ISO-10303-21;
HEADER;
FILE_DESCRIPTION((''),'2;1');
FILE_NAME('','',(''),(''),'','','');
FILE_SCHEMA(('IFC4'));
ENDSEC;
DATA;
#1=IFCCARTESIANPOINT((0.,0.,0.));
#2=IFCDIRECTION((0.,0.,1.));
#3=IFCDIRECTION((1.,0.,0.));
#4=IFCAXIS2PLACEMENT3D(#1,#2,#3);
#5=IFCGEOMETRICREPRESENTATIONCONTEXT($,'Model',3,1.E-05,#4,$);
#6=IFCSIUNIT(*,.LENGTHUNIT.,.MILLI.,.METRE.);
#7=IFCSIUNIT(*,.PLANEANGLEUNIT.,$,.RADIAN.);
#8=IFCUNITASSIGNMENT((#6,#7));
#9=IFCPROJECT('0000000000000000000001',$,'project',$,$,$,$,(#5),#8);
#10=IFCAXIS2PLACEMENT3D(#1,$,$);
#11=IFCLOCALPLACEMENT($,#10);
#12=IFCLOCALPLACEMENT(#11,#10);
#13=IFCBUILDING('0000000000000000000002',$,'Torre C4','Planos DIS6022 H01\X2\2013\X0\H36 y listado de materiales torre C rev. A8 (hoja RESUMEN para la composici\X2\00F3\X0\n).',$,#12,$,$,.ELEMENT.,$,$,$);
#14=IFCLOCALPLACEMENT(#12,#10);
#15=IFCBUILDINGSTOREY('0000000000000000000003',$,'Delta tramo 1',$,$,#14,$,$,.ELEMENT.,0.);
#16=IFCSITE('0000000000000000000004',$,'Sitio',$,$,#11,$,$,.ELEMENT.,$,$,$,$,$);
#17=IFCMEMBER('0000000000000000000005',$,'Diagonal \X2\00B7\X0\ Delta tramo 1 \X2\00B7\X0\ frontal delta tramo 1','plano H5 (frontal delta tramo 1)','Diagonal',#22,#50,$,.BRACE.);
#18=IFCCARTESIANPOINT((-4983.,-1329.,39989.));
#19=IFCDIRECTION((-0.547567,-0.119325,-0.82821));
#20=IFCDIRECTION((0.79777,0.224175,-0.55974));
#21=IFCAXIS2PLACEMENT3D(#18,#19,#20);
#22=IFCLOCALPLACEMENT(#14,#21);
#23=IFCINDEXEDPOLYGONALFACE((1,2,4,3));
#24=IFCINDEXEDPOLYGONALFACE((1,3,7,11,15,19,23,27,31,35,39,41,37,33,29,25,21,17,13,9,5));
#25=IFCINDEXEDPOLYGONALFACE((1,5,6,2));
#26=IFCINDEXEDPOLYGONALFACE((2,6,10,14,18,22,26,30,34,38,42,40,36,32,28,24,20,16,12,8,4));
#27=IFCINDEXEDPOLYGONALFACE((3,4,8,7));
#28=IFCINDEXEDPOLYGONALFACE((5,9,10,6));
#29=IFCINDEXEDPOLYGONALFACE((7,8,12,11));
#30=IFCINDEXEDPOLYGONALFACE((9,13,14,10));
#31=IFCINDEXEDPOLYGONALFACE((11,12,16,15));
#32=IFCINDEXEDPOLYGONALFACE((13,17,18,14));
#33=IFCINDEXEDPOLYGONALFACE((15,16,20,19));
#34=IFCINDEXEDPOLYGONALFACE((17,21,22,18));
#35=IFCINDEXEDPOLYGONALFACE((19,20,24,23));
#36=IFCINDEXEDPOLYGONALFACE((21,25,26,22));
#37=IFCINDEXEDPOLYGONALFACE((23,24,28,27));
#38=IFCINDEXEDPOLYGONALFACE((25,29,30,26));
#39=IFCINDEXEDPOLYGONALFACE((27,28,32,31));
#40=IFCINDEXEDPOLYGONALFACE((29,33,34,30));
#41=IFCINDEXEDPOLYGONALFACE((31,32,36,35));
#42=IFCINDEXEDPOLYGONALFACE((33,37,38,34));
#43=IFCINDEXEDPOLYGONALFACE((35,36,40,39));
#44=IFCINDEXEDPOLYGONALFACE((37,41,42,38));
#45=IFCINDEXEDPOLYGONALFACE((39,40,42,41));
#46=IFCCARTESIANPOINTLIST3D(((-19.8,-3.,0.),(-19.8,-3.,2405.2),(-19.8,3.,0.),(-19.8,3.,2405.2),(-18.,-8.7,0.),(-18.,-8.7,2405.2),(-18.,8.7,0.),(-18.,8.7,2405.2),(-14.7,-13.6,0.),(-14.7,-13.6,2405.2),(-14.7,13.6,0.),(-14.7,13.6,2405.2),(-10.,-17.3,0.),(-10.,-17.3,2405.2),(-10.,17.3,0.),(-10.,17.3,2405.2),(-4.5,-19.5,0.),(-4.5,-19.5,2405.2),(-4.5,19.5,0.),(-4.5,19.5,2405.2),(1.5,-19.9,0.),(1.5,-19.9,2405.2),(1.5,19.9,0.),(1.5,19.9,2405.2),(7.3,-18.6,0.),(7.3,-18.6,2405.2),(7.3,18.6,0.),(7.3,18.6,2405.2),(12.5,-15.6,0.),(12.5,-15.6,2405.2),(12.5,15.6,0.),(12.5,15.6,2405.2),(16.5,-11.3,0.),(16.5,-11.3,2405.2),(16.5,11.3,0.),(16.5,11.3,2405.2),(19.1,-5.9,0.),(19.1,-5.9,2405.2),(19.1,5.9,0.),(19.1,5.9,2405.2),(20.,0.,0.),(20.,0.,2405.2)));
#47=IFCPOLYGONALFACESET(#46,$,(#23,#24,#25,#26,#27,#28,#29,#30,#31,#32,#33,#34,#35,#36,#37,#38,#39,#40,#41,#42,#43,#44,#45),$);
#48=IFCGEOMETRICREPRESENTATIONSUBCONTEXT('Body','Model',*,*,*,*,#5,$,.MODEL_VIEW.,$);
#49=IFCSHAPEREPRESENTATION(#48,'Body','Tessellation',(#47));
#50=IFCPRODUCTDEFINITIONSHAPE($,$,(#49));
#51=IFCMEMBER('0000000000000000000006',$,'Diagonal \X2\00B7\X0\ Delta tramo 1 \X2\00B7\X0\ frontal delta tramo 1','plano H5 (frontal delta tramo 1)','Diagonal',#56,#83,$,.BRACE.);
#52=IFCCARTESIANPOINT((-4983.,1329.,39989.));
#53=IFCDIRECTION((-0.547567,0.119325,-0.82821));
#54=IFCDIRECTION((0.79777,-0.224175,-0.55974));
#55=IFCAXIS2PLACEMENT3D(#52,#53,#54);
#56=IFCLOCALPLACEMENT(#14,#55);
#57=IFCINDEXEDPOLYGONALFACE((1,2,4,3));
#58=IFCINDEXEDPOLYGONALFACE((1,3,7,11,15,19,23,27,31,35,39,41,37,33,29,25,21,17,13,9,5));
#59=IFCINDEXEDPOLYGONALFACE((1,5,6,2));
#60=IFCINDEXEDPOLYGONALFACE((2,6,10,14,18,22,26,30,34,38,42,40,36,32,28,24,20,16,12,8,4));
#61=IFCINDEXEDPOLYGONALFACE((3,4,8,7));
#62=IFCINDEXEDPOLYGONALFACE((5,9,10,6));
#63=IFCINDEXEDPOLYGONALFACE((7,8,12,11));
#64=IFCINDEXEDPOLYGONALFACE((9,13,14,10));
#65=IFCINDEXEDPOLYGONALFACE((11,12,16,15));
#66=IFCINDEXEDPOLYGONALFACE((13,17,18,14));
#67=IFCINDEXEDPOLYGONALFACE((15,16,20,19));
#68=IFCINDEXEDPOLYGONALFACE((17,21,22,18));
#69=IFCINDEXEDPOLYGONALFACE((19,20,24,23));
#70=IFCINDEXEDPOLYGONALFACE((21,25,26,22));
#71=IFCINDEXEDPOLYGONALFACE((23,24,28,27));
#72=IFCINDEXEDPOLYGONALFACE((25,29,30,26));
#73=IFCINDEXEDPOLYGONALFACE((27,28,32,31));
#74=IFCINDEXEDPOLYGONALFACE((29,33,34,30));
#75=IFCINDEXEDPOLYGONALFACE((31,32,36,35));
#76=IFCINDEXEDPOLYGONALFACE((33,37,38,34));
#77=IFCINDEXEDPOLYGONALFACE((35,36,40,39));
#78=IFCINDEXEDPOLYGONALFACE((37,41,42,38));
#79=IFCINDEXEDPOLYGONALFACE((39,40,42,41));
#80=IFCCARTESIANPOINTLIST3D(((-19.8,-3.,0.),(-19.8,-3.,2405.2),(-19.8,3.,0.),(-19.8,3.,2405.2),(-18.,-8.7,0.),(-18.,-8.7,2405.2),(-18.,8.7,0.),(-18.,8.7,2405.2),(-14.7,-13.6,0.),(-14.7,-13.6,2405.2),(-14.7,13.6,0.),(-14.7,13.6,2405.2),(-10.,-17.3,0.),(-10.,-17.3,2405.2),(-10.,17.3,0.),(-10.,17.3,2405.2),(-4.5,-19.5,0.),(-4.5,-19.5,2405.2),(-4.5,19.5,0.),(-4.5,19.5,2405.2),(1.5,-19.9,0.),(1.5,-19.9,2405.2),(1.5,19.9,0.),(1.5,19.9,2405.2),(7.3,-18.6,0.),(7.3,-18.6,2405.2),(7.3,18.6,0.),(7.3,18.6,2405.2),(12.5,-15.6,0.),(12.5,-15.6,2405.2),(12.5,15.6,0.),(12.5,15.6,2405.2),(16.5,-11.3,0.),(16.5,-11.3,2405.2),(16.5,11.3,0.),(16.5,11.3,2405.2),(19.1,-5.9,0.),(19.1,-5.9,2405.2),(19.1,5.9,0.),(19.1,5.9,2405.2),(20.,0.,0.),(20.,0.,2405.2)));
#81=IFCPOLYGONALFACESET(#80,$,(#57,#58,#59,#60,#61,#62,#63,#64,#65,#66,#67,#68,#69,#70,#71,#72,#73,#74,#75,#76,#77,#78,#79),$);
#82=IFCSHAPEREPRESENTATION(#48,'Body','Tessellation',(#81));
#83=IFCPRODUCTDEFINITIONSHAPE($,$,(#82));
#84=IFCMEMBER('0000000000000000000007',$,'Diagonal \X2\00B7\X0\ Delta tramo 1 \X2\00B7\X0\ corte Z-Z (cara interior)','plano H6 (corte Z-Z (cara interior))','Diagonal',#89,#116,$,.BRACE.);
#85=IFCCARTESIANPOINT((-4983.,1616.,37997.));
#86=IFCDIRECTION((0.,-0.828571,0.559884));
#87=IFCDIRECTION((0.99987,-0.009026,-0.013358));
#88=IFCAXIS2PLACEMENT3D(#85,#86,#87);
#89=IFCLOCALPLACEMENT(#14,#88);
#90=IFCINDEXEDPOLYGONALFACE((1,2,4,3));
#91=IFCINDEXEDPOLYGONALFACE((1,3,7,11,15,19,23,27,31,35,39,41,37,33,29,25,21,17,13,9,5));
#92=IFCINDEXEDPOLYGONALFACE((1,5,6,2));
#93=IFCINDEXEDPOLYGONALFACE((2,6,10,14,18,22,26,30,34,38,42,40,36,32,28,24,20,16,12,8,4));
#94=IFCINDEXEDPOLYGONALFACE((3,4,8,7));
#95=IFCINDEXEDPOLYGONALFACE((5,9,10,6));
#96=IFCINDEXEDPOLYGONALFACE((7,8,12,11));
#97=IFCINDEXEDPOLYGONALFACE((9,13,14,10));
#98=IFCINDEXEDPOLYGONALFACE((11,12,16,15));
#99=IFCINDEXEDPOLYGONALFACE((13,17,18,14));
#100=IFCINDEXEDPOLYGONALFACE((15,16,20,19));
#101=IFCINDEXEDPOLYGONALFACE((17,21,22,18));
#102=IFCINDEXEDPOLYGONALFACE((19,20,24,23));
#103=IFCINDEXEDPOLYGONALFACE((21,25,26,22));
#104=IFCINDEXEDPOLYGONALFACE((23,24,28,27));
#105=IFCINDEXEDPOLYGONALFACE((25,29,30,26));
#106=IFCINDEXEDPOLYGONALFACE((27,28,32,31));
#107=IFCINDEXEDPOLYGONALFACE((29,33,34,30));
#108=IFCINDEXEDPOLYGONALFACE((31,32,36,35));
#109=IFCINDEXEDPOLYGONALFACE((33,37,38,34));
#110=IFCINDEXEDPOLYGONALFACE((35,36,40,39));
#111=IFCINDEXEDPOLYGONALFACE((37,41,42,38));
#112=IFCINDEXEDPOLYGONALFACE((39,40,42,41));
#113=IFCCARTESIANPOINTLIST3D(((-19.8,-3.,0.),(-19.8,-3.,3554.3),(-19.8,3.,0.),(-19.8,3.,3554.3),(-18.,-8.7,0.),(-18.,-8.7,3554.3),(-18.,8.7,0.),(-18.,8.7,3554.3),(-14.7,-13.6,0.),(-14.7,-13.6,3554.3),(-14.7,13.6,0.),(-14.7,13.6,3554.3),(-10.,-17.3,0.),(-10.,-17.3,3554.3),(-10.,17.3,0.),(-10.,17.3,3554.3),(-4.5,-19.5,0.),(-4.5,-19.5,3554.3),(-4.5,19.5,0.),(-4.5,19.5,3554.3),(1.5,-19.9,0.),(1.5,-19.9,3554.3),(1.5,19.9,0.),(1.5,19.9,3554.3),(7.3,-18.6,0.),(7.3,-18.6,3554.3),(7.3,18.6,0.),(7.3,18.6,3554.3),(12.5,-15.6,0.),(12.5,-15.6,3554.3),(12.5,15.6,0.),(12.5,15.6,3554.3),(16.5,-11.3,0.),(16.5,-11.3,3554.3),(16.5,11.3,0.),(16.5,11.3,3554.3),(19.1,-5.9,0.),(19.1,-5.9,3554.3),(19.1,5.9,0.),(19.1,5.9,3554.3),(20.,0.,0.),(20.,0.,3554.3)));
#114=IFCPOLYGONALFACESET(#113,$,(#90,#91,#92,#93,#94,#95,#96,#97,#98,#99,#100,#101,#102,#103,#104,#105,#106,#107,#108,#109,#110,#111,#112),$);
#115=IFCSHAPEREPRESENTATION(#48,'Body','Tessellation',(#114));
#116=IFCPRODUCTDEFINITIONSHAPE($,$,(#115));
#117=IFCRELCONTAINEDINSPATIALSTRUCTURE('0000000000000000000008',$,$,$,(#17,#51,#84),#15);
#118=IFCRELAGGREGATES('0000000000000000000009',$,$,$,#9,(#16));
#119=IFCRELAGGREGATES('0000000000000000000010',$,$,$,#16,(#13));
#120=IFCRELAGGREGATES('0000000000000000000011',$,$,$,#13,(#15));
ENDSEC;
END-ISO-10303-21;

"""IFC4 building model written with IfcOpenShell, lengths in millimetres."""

from ifc_helpers import new_model, si_unit, frame, origin, origin_with_axes, place, context, subcontext, project, spatial, circle, extrude, element, save


model = new_model("IFC4")

# Units and contexts
model_context = context("Model", 3, precision=1e-05, world=origin_with_axes())
body_context = subcontext(model_context, "Body", "Model", "MODEL_VIEW")
ifc_project = project(units=[si_unit("LENGTHUNIT", "METRE", prefix="MILLI"), si_unit("PLANEANGLEUNIT", "RADIAN")], contexts=[model_context])

# Site, building, storey
site_placement = place(None, origin())
site = spatial("IfcSite", under=ifc_project, at=site_placement, Name="Sitio", CompositionType="ELEMENT")
building_placement = place(site_placement, origin())
building = spatial("IfcBuilding", under=site, at=building_placement, Name="Torre C4", Description="Planos DIS6022 H01–H36 y listado de materiales torre C rev. A8 (hoja RESUMEN para la composición).", CompositionType="ELEMENT")
storey_placement = place(building_placement, origin())
storey = spatial("IfcBuildingStorey", under=building, at=storey_placement, Name="Delta tramo 1", CompositionType="ELEMENT", Elevation=0.0)

# Members
for number, where, z_axis, x_axis, name in (
    (1, (-4983.0, -1329.0, 39989.0), (-0.547567, -0.119325, -0.82821), (0.79777, 0.224175, -0.55974), "Diagonal · Delta tramo 1 · frontal delta tramo 1"),
    (2, (-4983.0, 1329.0, 39989.0), (-0.547567, 0.119325, -0.82821), (0.79777, -0.224175, -0.55974), "Diagonal · Delta tramo 1 · frontal delta tramo 1"),
):
    element("IfcMember", number, at=place(storey_placement, frame(where, z_axis=z_axis, x_axis=x_axis)), inside=storey, Name=name, Description="plano H5 (frontal delta tramo 1)", ObjectType="Diagonal", PredefinedType="BRACE", context=body_context, shape_type="SweptSolid", body=[
        extrude(circle(Radius=20.0), None, (0.0, 0.0, 1.0), 2405.2),
    ])
member_1_placement = place(storey_placement, frame((-4983.0, 1616.0, 37997.0), z_axis=(0.0, -0.828571, 0.559884), x_axis=(0.99987, -0.009026, -0.013358)))
element("IfcMember", 3, at=member_1_placement, inside=storey, Name="Diagonal · Delta tramo 1 · corte Z-Z (cara interior)", Description="plano H6 (corte Z-Z (cara interior))", ObjectType="Diagonal", PredefinedType="BRACE", context=body_context, shape_type="SweptSolid", body=[
    extrude(circle(Radius=20.0), None, (0.0, 0.0, 1.0), 3554.3),
])

save(model, "model.ifc")
